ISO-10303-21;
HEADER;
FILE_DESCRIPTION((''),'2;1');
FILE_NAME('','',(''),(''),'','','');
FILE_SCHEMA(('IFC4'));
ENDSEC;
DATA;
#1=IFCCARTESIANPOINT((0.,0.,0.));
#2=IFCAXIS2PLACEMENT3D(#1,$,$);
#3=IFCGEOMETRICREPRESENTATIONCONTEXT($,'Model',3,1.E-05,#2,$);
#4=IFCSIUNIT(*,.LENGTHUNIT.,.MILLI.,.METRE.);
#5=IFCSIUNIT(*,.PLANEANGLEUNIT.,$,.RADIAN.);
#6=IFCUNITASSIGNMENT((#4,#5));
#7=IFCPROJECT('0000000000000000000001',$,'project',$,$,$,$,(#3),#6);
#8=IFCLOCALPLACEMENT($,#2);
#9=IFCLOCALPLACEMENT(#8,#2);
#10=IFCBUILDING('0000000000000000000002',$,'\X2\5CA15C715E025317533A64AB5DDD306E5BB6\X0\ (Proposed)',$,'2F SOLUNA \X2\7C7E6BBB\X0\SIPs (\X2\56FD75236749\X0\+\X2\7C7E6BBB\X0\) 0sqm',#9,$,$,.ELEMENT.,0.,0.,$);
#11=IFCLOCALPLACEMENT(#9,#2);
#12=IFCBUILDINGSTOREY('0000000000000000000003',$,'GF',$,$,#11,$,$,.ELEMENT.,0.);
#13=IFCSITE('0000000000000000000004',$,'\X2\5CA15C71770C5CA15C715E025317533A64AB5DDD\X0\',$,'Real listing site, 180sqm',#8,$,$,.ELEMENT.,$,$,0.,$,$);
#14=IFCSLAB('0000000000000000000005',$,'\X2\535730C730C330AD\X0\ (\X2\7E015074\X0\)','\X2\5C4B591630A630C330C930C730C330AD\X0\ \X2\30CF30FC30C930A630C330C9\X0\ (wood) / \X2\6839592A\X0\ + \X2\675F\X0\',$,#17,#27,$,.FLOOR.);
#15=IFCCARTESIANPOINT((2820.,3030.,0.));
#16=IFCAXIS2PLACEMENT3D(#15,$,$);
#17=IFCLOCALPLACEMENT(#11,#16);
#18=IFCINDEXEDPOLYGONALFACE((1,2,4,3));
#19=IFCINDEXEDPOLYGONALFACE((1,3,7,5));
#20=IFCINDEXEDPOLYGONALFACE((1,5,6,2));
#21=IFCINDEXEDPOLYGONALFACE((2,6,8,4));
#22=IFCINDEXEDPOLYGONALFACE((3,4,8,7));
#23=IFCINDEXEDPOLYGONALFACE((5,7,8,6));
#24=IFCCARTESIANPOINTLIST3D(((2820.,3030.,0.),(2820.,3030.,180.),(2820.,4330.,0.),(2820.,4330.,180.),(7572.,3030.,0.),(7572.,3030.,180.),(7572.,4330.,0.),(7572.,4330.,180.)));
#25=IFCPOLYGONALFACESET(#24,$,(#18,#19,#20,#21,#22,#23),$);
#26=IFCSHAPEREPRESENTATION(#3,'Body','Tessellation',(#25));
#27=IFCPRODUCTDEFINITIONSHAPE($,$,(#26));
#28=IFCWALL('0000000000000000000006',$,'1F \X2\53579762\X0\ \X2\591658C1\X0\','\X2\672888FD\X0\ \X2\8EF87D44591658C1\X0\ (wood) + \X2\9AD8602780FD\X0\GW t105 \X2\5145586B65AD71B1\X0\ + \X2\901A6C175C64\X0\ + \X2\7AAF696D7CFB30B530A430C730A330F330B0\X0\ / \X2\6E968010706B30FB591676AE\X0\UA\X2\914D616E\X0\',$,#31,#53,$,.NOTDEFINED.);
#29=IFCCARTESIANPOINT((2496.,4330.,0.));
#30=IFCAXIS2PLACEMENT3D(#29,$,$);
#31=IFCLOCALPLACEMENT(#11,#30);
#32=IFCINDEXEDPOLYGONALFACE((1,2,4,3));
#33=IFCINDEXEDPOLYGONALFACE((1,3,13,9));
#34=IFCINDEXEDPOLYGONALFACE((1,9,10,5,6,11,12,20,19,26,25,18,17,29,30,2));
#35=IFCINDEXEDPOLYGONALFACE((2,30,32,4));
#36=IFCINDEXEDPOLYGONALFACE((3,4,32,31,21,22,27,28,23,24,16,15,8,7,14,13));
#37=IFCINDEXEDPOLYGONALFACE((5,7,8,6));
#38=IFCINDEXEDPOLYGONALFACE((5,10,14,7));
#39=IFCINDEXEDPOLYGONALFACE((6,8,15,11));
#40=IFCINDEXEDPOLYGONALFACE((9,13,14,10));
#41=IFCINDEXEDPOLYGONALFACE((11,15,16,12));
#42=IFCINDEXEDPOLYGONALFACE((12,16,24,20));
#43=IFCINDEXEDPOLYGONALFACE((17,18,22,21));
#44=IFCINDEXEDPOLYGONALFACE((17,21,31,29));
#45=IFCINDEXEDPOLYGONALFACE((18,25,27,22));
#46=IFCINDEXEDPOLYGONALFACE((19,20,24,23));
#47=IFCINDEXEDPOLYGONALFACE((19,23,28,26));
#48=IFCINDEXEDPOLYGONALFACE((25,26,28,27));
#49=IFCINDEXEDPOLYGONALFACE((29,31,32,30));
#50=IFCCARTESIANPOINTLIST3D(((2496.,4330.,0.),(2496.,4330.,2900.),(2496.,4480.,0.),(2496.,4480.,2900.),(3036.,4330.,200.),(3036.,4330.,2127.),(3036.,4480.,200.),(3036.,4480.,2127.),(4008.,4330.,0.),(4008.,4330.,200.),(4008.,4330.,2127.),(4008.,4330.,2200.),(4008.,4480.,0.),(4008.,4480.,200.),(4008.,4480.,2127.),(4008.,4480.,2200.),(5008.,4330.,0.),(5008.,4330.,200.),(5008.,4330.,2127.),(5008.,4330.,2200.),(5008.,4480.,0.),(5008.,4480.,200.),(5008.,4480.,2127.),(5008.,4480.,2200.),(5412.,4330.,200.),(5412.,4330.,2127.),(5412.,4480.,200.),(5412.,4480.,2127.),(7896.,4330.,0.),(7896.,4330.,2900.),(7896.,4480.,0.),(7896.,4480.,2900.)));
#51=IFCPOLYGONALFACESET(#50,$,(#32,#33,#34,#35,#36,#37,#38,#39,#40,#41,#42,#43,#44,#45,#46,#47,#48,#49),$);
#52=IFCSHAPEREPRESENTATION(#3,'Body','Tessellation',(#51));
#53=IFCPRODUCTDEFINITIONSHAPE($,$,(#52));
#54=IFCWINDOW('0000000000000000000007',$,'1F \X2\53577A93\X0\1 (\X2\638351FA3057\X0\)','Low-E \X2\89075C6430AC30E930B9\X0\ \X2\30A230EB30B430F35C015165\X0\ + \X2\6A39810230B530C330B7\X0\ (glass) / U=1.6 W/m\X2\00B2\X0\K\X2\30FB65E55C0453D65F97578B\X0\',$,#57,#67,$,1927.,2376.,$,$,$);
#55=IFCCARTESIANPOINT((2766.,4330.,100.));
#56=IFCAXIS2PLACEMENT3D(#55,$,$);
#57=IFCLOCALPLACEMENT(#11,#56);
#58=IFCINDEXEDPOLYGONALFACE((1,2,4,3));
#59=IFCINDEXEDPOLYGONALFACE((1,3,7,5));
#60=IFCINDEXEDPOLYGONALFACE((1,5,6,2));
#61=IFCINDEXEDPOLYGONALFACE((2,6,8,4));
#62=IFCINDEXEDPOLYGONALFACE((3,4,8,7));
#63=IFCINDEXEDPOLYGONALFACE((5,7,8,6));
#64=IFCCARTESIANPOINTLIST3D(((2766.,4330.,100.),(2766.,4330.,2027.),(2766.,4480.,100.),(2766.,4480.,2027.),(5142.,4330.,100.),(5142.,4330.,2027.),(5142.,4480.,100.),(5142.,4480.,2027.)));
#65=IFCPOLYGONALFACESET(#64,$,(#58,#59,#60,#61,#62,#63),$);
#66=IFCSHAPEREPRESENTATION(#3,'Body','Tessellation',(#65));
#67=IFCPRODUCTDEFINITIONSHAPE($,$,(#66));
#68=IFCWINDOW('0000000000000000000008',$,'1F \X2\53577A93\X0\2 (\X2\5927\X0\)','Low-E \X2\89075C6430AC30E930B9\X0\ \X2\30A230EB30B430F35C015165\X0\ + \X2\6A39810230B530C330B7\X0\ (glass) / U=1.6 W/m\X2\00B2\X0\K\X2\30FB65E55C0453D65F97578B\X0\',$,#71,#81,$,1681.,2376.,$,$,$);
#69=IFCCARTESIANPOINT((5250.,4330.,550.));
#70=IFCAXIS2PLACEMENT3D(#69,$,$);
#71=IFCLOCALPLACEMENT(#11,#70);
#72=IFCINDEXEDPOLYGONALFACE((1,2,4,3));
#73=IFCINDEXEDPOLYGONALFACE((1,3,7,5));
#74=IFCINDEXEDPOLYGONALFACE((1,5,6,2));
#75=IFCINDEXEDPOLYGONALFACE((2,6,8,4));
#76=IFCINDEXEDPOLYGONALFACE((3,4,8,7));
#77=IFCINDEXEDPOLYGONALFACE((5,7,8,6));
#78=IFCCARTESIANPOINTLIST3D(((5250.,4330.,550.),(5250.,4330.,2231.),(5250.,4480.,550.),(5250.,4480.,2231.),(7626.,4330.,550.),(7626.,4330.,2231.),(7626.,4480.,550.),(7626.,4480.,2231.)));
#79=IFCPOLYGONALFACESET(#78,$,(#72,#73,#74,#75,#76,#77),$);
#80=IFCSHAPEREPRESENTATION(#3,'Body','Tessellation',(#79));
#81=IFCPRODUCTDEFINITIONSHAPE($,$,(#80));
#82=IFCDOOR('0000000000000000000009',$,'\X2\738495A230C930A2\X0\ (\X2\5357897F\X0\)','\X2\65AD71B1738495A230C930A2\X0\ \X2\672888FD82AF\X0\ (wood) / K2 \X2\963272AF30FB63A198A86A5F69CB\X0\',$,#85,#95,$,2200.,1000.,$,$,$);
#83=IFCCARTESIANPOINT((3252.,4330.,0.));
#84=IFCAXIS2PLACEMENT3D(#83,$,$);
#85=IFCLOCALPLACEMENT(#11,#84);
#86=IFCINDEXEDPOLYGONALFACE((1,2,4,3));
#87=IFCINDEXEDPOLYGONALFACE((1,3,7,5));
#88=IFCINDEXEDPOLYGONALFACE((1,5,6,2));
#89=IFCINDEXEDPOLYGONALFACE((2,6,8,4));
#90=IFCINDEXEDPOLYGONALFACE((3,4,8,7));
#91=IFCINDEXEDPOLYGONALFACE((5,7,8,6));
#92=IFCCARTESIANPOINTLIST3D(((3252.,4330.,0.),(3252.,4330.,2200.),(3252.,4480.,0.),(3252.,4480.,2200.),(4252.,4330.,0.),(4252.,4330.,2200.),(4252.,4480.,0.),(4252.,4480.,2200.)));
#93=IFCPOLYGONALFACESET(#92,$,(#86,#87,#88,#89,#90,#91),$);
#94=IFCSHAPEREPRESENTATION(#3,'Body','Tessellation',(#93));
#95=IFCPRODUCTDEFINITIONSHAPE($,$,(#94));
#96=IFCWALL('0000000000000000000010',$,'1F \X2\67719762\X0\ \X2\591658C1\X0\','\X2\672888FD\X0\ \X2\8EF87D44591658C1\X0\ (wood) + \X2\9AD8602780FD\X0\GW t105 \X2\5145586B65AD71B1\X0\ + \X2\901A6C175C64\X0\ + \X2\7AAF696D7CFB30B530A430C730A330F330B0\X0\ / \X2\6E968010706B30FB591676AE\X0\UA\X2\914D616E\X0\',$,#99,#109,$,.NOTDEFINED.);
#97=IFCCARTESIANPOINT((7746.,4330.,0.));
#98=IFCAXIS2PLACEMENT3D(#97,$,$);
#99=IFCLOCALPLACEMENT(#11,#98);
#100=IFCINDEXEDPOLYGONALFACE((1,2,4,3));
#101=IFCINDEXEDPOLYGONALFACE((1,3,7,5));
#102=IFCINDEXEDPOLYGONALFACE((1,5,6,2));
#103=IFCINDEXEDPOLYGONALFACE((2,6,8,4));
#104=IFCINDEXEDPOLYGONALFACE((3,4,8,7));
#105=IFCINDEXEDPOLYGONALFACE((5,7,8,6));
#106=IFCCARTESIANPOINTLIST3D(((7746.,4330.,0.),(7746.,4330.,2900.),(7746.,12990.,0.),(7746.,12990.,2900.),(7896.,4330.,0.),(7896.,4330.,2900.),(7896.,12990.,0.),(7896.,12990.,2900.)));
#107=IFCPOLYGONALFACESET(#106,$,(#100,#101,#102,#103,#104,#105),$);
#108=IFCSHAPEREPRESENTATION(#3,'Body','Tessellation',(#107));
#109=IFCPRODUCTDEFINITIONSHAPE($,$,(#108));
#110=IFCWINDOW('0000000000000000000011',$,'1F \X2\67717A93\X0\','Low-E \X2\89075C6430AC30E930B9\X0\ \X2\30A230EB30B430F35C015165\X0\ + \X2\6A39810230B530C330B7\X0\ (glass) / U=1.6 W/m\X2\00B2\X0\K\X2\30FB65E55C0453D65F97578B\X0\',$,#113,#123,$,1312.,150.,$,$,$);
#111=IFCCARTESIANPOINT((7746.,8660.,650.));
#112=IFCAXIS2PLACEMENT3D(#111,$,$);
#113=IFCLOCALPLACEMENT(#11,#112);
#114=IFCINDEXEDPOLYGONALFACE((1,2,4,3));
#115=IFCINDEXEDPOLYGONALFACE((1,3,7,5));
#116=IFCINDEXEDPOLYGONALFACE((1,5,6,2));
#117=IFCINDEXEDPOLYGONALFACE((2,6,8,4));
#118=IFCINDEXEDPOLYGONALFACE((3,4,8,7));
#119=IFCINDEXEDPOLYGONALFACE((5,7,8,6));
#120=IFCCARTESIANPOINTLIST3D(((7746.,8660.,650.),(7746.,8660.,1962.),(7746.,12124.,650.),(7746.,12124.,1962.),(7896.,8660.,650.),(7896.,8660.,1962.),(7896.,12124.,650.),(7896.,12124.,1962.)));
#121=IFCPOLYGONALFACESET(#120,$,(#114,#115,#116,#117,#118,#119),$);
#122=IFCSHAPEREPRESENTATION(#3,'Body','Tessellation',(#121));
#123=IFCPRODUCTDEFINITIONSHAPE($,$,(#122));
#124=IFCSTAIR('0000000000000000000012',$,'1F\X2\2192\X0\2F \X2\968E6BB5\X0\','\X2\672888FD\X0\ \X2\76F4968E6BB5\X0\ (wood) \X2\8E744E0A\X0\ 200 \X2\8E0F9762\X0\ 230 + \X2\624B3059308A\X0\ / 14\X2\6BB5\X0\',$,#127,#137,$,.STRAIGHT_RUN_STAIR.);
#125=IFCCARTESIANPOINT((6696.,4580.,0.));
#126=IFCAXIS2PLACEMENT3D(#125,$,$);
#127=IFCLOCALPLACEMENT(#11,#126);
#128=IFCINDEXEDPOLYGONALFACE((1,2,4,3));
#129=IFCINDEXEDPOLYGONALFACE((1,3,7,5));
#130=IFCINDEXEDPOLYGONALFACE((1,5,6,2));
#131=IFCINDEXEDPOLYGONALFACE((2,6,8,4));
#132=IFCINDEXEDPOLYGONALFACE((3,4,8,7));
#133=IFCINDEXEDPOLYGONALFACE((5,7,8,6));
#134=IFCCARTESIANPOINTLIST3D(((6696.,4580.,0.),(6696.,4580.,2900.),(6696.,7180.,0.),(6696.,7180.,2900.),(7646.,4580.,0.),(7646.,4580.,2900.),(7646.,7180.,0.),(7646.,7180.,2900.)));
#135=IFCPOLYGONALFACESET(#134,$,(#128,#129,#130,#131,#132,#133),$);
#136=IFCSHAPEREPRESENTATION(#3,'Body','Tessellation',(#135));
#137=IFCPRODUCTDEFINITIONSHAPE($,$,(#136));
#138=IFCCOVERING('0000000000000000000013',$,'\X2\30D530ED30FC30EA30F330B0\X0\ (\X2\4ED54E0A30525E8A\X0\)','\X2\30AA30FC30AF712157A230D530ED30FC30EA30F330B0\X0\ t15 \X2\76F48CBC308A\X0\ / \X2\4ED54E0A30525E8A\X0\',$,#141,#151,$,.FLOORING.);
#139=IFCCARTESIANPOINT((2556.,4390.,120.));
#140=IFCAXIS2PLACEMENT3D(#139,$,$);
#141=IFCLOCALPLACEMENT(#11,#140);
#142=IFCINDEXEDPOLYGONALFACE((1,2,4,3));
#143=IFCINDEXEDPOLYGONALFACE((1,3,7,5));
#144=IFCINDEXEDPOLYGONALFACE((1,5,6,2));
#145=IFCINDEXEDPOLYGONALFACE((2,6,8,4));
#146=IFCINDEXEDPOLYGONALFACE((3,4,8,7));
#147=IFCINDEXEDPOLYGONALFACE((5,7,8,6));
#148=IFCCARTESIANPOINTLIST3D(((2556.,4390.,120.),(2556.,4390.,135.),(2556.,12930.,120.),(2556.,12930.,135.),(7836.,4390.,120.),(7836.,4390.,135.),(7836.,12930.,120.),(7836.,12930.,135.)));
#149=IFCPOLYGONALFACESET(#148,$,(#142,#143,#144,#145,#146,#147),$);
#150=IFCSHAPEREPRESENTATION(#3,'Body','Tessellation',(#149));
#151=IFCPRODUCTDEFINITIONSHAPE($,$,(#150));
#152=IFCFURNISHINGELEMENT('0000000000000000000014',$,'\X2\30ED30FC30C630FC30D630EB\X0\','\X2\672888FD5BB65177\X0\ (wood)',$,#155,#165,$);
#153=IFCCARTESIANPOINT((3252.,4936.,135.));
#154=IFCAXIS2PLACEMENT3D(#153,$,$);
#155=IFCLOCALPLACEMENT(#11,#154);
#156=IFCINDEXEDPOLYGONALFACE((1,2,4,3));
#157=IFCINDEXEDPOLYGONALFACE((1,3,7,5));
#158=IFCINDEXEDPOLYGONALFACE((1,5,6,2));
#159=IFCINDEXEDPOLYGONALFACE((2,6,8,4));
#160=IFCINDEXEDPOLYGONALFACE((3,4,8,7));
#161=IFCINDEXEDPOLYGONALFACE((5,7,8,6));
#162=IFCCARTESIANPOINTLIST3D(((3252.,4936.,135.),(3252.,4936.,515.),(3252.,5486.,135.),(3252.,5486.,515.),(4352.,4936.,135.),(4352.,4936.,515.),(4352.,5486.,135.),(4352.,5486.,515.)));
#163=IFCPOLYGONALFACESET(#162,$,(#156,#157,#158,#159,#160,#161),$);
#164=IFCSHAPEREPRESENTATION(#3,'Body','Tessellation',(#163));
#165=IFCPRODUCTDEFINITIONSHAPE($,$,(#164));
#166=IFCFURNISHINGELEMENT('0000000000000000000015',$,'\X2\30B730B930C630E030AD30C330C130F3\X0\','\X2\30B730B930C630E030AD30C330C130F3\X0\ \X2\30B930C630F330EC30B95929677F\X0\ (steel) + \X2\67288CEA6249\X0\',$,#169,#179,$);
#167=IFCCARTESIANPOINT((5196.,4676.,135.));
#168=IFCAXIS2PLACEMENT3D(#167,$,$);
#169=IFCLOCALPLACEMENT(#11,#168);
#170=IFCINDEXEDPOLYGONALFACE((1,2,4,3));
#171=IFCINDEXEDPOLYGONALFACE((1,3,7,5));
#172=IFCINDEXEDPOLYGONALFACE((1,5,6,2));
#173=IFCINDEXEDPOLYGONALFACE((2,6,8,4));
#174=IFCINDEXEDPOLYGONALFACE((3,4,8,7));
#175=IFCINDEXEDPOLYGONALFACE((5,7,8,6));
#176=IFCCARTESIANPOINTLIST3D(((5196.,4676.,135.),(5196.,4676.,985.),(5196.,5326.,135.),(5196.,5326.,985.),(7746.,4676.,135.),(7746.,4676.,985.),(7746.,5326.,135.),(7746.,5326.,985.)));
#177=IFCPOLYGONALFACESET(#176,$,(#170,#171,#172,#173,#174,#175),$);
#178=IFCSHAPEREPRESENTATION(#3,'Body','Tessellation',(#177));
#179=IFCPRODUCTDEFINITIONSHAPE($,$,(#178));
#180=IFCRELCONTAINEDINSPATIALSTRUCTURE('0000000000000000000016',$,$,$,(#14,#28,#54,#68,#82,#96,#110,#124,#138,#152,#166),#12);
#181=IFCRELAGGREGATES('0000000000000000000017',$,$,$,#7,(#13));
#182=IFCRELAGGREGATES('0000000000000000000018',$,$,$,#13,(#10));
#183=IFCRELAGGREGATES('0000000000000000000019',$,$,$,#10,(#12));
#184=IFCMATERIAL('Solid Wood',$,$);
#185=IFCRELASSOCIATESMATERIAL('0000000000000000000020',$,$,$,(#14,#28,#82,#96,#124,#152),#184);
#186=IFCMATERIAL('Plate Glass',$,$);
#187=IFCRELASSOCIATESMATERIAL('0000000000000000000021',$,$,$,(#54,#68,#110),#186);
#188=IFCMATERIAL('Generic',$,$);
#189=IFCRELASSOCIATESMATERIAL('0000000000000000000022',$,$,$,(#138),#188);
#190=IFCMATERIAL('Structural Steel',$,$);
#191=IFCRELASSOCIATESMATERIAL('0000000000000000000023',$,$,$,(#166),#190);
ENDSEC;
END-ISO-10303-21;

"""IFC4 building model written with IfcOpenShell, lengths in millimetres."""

from ifc_helpers import new_model, si_unit, frame, frame_2d, origin, place, context, project, spatial, rectangle, extrude, material, element, fill, save


model = new_model("IFC4")

# Units and contexts
model_context = context("Model", 3, precision=1e-05, world=origin())
ifc_project = project(units=[si_unit("LENGTHUNIT", "METRE", prefix="MILLI"), si_unit("PLANEANGLEUNIT", "RADIAN")], contexts=[model_context])

# Site, building, storey
site_placement = place(None, origin())
site = spatial("IfcSite", under=ifc_project, at=site_placement, Name="岡山県岡山市北区撫川", ObjectType="Real listing site, 180sqm", CompositionType="ELEMENT", RefElevation=0.0)
building_placement = place(site_placement, origin())
building = spatial("IfcBuilding", under=site, at=building_placement, Name="岡山市北区撫川の家 (Proposed)", ObjectType="2F SOLUNA 籾殻SIPs (国産杉+籾殻) 0sqm", CompositionType="ELEMENT", ElevationOfRefHeight=0.0, ElevationOfTerrain=0.0)
storey_placement = place(building_placement, origin())
storey = spatial("IfcBuildingStorey", under=building, at=storey_placement, Name="GF", CompositionType="ELEMENT", Elevation=0.0)

# Slab
ifc_material_1 = material(Name="Solid Wood")
slab_1_placement = place(storey_placement, frame((2820.0, 3030.0, 0.0)))
element("IfcSlab", 1, at=slab_1_placement, inside=storey, material=ifc_material_1, Name="南デッキ (縁側)", Description="屋外ウッドデッキ ハードウッド (wood) / 根太 + 束", PredefinedType="FLOOR", context=model_context, shape_type="SweptSolid", body=[
    extrude(rectangle(XDim=4752.0, YDim=1300.0, at=frame_2d((2376.0, 650.0))), frame((2820.0, 3030.0, 0.0)), (0.0, 0.0, 1.0), 180.0),
])

# Wall, openings, windows, door
wall_1_placement = place(storey_placement, frame((2496.0, 4330.0, 0.0)))
wall_1 = element("IfcWall", 2, at=wall_1_placement, inside=storey, material=ifc_material_1, Name="1F 南面 外壁", Description="木製 軸組外壁 (wood) + 高性能GW t105 充填断熱 + 通気層 + 窯業系サイディング / 準耐火・外皮UA配慮", PredefinedType="NOTDEFINED", context=model_context, shape_type="SweptSolid", body=[
    extrude(rectangle(XDim=5400.0, YDim=150.0, at=frame_2d((2700.0, 75.0))), frame((2496.0, 4330.0, 0.0)), (0.0, 0.0, 1.0), 2900.0),
])
opening_1_placement = place(storey_placement, frame((2766.0, 4330.0, 100.0)))
opening_1 = element("IfcOpeningElement", 3, at=opening_1_placement, cuts=wall_1, PredefinedType="NOTDEFINED", context=model_context, shape_type="SweptSolid", body=[
    extrude(rectangle(XDim=2376.0, YDim=150.0, at=frame_2d((1188.0, 75.0))), frame((2766.0, 4330.0, 100.0)), (0.0, 0.0, 1.0), 1927.0),
])
opening_2_placement = place(storey_placement, frame((5250.0, 4330.0, 550.0)))
opening_2 = element("IfcOpeningElement", 4, at=opening_2_placement, cuts=wall_1, PredefinedType="NOTDEFINED", context=model_context, shape_type="SweptSolid", body=[
    extrude(rectangle(XDim=2376.0, YDim=150.0, at=frame_2d((1188.0, 75.0))), frame((5250.0, 4330.0, 550.0)), (0.0, 0.0, 1.0), 1681.0),
])
opening_3_placement = place(storey_placement, frame((3252.0, 4330.0, 0.0)))
opening_3 = element("IfcOpeningElement", 5, at=opening_3_placement, cuts=wall_1, PredefinedType="NOTDEFINED", context=model_context, shape_type="SweptSolid", body=[
    extrude(rectangle(XDim=1000.0, YDim=150.0, at=frame_2d((500.0, 75.0))), frame((3252.0, 4330.0, 0.0)), (0.0, 0.0, 1.0), 2200.0),
])
ifc_material_2 = material(Name="Plate Glass")
window_1_placement = place(storey_placement, frame((2766.0, 4330.0, 100.0)))
window_1 = element("IfcWindow", 6, at=window_1_placement, inside=storey, material=ifc_material_2, Name="1F 南窓1 (掃出し)", Description="Low-E 複層ガラス アルゴン封入 + 樹脂サッシ (glass) / U=1.6 W/m²K・日射取得型", OverallHeight=1927.0, OverallWidth=2376.0, context=model_context, shape_type="SweptSolid", body=[
    extrude(rectangle(XDim=2376.0, YDim=150.0, at=frame_2d((1188.0, 75.0))), frame((2766.0, 4330.0, 100.0)), (0.0, 0.0, 1.0), 1927.0),
])
fill(opening_1, window_1)
window_2_placement = place(storey_placement, frame((5250.0, 4330.0, 550.0)))
window_2 = element("IfcWindow", 7, at=window_2_placement, inside=storey, material=ifc_material_2, Name="1F 南窓2 (大)", Description="Low-E 複層ガラス アルゴン封入 + 樹脂サッシ (glass) / U=1.6 W/m²K・日射取得型", OverallHeight=1681.0, OverallWidth=2376.0, context=model_context, shape_type="SweptSolid", body=[
    extrude(rectangle(XDim=2376.0, YDim=150.0, at=frame_2d((1188.0, 75.0))), frame((5250.0, 4330.0, 550.0)), (0.0, 0.0, 1.0), 1681.0),
])
fill(opening_2, window_2)
door_placement = place(storey_placement, frame((3252.0, 4330.0, 0.0)))
door = element("IfcDoor", 8, at=door_placement, inside=storey, material=ifc_material_1, Name="玄関ドア (南西)", Description="断熱玄関ドア 木製芯 (wood) / K2 防犯・採風機構", OverallHeight=2200.0, OverallWidth=1000.0, context=model_context, shape_type="SweptSolid", body=[
    extrude(rectangle(XDim=1000.0, YDim=150.0, at=frame_2d((500.0, 75.0))), frame((3252.0, 4330.0, 0.0)), (0.0, 0.0, 1.0), 2200.0),
])
fill(opening_3, door)

# Wall, opening, window
wall_2_placement = place(storey_placement, frame((7746.0, 4330.0, 0.0)))
wall_2 = element("IfcWall", 9, at=wall_2_placement, inside=storey, material=ifc_material_1, Name="1F 東面 外壁", Description="木製 軸組外壁 (wood) + 高性能GW t105 充填断熱 + 通気層 + 窯業系サイディング / 準耐火・外皮UA配慮", PredefinedType="NOTDEFINED", context=model_context, shape_type="SweptSolid", body=[
    extrude(rectangle(XDim=150.0, YDim=8660.0, at=frame_2d((75.0, 4330.0))), frame((7746.0, 4330.0, 0.0)), (0.0, 0.0, 1.0), 2900.0),
])
opening_4_placement = place(storey_placement, frame((7746.0, 8660.0, 650.0)))
opening_4 = element("IfcOpeningElement", 10, at=opening_4_placement, cuts=wall_2, PredefinedType="NOTDEFINED", context=model_context, shape_type="SweptSolid", body=[
    extrude(rectangle(XDim=150.0, YDim=3464.0, at=frame_2d((75.0, 1732.0))), frame((7746.0, 8660.0, 650.0)), (0.0, 0.0, 1.0), 1312.0),
])
window_3_placement = place(storey_placement, frame((7746.0, 8660.0, 650.0)))
window_3 = element("IfcWindow", 11, at=window_3_placement, inside=storey, material=ifc_material_2, Name="1F 東窓", Description="Low-E 複層ガラス アルゴン封入 + 樹脂サッシ (glass) / U=1.6 W/m²K・日射取得型", OverallHeight=1312.0, OverallWidth=150.0, context=model_context, shape_type="SweptSolid", body=[
    extrude(rectangle(XDim=150.0, YDim=3464.0, at=frame_2d((75.0, 1732.0))), frame((7746.0, 8660.0, 650.0)), (0.0, 0.0, 1.0), 1312.0),
])
fill(opening_4, window_3)

# Stair
stair_placement = place(storey_placement, frame((6696.0, 4580.0, 0.0)))
element("IfcStair", 12, at=stair_placement, inside=storey, material=ifc_material_1, Name="1F→2F 階段", Description="木製 直階段 (wood) 蹴上 200 踏面 230 + 手すり / 14段", PredefinedType="STRAIGHT_RUN_STAIR", context=model_context, shape_type="SweptSolid", body=[
    extrude(rectangle(XDim=950.0, YDim=2600.0, at=frame_2d((475.0, 1300.0))), frame((6696.0, 4580.0, 0.0)), (0.0, 0.0, 1.0), 2900.0),
])

# Covering
ifc_material_3 = material(Name="Generic")
covering_placement = place(storey_placement, frame((2556.0, 4390.0, 120.0)))
element("IfcCovering", 13, at=covering_placement, inside=storey, material=ifc_material_3, Name="フローリング (仕上げ床)", Description="オーク無垢フローリング t15 直貼り / 仕上げ床", PredefinedType="FLOORING", context=model_context, shape_type="SweptSolid", body=[
    extrude(rectangle(XDim=5280.0, YDim=8540.0, at=frame_2d((2640.0, 4270.0))), frame((2556.0, 4390.0, 120.0)), (0.0, 0.0, 1.0), 15.0),
])

# Furnishing elements
furnishing_1_placement = place(storey_placement, frame((3252.0, 4936.0, 135.0)))
element("IfcFurnishingElement", 14, at=furnishing_1_placement, inside=storey, material=ifc_material_1, Name="ローテーブル", Description="木製家具 (wood)", context=model_context, shape_type="SweptSolid", body=[
    extrude(rectangle(XDim=1100.0, YDim=550.0, at=frame_2d((550.0, 275.0))), frame((3252.0, 4936.0, 135.0)), (0.0, 0.0, 1.0), 380.0),
])
ifc_material_4 = material(Name="Structural Steel")
furnishing_2_placement = place(storey_placement, frame((5196.0, 4676.0, 135.0)))
element("IfcFurnishingElement", 15, at=furnishing_2_placement, inside=storey, material=ifc_material_4, Name="システムキッチン", Description="システムキッチン ステンレス天板 (steel) + 木質扉", context=model_context, shape_type="SweptSolid", body=[
    extrude(rectangle(XDim=2550.0, YDim=650.0, at=frame_2d((1275.0, 325.0))), frame((5196.0, 4676.0, 135.0)), (0.0, 0.0, 1.0), 850.0),
])

save(model, "model.ifc")
